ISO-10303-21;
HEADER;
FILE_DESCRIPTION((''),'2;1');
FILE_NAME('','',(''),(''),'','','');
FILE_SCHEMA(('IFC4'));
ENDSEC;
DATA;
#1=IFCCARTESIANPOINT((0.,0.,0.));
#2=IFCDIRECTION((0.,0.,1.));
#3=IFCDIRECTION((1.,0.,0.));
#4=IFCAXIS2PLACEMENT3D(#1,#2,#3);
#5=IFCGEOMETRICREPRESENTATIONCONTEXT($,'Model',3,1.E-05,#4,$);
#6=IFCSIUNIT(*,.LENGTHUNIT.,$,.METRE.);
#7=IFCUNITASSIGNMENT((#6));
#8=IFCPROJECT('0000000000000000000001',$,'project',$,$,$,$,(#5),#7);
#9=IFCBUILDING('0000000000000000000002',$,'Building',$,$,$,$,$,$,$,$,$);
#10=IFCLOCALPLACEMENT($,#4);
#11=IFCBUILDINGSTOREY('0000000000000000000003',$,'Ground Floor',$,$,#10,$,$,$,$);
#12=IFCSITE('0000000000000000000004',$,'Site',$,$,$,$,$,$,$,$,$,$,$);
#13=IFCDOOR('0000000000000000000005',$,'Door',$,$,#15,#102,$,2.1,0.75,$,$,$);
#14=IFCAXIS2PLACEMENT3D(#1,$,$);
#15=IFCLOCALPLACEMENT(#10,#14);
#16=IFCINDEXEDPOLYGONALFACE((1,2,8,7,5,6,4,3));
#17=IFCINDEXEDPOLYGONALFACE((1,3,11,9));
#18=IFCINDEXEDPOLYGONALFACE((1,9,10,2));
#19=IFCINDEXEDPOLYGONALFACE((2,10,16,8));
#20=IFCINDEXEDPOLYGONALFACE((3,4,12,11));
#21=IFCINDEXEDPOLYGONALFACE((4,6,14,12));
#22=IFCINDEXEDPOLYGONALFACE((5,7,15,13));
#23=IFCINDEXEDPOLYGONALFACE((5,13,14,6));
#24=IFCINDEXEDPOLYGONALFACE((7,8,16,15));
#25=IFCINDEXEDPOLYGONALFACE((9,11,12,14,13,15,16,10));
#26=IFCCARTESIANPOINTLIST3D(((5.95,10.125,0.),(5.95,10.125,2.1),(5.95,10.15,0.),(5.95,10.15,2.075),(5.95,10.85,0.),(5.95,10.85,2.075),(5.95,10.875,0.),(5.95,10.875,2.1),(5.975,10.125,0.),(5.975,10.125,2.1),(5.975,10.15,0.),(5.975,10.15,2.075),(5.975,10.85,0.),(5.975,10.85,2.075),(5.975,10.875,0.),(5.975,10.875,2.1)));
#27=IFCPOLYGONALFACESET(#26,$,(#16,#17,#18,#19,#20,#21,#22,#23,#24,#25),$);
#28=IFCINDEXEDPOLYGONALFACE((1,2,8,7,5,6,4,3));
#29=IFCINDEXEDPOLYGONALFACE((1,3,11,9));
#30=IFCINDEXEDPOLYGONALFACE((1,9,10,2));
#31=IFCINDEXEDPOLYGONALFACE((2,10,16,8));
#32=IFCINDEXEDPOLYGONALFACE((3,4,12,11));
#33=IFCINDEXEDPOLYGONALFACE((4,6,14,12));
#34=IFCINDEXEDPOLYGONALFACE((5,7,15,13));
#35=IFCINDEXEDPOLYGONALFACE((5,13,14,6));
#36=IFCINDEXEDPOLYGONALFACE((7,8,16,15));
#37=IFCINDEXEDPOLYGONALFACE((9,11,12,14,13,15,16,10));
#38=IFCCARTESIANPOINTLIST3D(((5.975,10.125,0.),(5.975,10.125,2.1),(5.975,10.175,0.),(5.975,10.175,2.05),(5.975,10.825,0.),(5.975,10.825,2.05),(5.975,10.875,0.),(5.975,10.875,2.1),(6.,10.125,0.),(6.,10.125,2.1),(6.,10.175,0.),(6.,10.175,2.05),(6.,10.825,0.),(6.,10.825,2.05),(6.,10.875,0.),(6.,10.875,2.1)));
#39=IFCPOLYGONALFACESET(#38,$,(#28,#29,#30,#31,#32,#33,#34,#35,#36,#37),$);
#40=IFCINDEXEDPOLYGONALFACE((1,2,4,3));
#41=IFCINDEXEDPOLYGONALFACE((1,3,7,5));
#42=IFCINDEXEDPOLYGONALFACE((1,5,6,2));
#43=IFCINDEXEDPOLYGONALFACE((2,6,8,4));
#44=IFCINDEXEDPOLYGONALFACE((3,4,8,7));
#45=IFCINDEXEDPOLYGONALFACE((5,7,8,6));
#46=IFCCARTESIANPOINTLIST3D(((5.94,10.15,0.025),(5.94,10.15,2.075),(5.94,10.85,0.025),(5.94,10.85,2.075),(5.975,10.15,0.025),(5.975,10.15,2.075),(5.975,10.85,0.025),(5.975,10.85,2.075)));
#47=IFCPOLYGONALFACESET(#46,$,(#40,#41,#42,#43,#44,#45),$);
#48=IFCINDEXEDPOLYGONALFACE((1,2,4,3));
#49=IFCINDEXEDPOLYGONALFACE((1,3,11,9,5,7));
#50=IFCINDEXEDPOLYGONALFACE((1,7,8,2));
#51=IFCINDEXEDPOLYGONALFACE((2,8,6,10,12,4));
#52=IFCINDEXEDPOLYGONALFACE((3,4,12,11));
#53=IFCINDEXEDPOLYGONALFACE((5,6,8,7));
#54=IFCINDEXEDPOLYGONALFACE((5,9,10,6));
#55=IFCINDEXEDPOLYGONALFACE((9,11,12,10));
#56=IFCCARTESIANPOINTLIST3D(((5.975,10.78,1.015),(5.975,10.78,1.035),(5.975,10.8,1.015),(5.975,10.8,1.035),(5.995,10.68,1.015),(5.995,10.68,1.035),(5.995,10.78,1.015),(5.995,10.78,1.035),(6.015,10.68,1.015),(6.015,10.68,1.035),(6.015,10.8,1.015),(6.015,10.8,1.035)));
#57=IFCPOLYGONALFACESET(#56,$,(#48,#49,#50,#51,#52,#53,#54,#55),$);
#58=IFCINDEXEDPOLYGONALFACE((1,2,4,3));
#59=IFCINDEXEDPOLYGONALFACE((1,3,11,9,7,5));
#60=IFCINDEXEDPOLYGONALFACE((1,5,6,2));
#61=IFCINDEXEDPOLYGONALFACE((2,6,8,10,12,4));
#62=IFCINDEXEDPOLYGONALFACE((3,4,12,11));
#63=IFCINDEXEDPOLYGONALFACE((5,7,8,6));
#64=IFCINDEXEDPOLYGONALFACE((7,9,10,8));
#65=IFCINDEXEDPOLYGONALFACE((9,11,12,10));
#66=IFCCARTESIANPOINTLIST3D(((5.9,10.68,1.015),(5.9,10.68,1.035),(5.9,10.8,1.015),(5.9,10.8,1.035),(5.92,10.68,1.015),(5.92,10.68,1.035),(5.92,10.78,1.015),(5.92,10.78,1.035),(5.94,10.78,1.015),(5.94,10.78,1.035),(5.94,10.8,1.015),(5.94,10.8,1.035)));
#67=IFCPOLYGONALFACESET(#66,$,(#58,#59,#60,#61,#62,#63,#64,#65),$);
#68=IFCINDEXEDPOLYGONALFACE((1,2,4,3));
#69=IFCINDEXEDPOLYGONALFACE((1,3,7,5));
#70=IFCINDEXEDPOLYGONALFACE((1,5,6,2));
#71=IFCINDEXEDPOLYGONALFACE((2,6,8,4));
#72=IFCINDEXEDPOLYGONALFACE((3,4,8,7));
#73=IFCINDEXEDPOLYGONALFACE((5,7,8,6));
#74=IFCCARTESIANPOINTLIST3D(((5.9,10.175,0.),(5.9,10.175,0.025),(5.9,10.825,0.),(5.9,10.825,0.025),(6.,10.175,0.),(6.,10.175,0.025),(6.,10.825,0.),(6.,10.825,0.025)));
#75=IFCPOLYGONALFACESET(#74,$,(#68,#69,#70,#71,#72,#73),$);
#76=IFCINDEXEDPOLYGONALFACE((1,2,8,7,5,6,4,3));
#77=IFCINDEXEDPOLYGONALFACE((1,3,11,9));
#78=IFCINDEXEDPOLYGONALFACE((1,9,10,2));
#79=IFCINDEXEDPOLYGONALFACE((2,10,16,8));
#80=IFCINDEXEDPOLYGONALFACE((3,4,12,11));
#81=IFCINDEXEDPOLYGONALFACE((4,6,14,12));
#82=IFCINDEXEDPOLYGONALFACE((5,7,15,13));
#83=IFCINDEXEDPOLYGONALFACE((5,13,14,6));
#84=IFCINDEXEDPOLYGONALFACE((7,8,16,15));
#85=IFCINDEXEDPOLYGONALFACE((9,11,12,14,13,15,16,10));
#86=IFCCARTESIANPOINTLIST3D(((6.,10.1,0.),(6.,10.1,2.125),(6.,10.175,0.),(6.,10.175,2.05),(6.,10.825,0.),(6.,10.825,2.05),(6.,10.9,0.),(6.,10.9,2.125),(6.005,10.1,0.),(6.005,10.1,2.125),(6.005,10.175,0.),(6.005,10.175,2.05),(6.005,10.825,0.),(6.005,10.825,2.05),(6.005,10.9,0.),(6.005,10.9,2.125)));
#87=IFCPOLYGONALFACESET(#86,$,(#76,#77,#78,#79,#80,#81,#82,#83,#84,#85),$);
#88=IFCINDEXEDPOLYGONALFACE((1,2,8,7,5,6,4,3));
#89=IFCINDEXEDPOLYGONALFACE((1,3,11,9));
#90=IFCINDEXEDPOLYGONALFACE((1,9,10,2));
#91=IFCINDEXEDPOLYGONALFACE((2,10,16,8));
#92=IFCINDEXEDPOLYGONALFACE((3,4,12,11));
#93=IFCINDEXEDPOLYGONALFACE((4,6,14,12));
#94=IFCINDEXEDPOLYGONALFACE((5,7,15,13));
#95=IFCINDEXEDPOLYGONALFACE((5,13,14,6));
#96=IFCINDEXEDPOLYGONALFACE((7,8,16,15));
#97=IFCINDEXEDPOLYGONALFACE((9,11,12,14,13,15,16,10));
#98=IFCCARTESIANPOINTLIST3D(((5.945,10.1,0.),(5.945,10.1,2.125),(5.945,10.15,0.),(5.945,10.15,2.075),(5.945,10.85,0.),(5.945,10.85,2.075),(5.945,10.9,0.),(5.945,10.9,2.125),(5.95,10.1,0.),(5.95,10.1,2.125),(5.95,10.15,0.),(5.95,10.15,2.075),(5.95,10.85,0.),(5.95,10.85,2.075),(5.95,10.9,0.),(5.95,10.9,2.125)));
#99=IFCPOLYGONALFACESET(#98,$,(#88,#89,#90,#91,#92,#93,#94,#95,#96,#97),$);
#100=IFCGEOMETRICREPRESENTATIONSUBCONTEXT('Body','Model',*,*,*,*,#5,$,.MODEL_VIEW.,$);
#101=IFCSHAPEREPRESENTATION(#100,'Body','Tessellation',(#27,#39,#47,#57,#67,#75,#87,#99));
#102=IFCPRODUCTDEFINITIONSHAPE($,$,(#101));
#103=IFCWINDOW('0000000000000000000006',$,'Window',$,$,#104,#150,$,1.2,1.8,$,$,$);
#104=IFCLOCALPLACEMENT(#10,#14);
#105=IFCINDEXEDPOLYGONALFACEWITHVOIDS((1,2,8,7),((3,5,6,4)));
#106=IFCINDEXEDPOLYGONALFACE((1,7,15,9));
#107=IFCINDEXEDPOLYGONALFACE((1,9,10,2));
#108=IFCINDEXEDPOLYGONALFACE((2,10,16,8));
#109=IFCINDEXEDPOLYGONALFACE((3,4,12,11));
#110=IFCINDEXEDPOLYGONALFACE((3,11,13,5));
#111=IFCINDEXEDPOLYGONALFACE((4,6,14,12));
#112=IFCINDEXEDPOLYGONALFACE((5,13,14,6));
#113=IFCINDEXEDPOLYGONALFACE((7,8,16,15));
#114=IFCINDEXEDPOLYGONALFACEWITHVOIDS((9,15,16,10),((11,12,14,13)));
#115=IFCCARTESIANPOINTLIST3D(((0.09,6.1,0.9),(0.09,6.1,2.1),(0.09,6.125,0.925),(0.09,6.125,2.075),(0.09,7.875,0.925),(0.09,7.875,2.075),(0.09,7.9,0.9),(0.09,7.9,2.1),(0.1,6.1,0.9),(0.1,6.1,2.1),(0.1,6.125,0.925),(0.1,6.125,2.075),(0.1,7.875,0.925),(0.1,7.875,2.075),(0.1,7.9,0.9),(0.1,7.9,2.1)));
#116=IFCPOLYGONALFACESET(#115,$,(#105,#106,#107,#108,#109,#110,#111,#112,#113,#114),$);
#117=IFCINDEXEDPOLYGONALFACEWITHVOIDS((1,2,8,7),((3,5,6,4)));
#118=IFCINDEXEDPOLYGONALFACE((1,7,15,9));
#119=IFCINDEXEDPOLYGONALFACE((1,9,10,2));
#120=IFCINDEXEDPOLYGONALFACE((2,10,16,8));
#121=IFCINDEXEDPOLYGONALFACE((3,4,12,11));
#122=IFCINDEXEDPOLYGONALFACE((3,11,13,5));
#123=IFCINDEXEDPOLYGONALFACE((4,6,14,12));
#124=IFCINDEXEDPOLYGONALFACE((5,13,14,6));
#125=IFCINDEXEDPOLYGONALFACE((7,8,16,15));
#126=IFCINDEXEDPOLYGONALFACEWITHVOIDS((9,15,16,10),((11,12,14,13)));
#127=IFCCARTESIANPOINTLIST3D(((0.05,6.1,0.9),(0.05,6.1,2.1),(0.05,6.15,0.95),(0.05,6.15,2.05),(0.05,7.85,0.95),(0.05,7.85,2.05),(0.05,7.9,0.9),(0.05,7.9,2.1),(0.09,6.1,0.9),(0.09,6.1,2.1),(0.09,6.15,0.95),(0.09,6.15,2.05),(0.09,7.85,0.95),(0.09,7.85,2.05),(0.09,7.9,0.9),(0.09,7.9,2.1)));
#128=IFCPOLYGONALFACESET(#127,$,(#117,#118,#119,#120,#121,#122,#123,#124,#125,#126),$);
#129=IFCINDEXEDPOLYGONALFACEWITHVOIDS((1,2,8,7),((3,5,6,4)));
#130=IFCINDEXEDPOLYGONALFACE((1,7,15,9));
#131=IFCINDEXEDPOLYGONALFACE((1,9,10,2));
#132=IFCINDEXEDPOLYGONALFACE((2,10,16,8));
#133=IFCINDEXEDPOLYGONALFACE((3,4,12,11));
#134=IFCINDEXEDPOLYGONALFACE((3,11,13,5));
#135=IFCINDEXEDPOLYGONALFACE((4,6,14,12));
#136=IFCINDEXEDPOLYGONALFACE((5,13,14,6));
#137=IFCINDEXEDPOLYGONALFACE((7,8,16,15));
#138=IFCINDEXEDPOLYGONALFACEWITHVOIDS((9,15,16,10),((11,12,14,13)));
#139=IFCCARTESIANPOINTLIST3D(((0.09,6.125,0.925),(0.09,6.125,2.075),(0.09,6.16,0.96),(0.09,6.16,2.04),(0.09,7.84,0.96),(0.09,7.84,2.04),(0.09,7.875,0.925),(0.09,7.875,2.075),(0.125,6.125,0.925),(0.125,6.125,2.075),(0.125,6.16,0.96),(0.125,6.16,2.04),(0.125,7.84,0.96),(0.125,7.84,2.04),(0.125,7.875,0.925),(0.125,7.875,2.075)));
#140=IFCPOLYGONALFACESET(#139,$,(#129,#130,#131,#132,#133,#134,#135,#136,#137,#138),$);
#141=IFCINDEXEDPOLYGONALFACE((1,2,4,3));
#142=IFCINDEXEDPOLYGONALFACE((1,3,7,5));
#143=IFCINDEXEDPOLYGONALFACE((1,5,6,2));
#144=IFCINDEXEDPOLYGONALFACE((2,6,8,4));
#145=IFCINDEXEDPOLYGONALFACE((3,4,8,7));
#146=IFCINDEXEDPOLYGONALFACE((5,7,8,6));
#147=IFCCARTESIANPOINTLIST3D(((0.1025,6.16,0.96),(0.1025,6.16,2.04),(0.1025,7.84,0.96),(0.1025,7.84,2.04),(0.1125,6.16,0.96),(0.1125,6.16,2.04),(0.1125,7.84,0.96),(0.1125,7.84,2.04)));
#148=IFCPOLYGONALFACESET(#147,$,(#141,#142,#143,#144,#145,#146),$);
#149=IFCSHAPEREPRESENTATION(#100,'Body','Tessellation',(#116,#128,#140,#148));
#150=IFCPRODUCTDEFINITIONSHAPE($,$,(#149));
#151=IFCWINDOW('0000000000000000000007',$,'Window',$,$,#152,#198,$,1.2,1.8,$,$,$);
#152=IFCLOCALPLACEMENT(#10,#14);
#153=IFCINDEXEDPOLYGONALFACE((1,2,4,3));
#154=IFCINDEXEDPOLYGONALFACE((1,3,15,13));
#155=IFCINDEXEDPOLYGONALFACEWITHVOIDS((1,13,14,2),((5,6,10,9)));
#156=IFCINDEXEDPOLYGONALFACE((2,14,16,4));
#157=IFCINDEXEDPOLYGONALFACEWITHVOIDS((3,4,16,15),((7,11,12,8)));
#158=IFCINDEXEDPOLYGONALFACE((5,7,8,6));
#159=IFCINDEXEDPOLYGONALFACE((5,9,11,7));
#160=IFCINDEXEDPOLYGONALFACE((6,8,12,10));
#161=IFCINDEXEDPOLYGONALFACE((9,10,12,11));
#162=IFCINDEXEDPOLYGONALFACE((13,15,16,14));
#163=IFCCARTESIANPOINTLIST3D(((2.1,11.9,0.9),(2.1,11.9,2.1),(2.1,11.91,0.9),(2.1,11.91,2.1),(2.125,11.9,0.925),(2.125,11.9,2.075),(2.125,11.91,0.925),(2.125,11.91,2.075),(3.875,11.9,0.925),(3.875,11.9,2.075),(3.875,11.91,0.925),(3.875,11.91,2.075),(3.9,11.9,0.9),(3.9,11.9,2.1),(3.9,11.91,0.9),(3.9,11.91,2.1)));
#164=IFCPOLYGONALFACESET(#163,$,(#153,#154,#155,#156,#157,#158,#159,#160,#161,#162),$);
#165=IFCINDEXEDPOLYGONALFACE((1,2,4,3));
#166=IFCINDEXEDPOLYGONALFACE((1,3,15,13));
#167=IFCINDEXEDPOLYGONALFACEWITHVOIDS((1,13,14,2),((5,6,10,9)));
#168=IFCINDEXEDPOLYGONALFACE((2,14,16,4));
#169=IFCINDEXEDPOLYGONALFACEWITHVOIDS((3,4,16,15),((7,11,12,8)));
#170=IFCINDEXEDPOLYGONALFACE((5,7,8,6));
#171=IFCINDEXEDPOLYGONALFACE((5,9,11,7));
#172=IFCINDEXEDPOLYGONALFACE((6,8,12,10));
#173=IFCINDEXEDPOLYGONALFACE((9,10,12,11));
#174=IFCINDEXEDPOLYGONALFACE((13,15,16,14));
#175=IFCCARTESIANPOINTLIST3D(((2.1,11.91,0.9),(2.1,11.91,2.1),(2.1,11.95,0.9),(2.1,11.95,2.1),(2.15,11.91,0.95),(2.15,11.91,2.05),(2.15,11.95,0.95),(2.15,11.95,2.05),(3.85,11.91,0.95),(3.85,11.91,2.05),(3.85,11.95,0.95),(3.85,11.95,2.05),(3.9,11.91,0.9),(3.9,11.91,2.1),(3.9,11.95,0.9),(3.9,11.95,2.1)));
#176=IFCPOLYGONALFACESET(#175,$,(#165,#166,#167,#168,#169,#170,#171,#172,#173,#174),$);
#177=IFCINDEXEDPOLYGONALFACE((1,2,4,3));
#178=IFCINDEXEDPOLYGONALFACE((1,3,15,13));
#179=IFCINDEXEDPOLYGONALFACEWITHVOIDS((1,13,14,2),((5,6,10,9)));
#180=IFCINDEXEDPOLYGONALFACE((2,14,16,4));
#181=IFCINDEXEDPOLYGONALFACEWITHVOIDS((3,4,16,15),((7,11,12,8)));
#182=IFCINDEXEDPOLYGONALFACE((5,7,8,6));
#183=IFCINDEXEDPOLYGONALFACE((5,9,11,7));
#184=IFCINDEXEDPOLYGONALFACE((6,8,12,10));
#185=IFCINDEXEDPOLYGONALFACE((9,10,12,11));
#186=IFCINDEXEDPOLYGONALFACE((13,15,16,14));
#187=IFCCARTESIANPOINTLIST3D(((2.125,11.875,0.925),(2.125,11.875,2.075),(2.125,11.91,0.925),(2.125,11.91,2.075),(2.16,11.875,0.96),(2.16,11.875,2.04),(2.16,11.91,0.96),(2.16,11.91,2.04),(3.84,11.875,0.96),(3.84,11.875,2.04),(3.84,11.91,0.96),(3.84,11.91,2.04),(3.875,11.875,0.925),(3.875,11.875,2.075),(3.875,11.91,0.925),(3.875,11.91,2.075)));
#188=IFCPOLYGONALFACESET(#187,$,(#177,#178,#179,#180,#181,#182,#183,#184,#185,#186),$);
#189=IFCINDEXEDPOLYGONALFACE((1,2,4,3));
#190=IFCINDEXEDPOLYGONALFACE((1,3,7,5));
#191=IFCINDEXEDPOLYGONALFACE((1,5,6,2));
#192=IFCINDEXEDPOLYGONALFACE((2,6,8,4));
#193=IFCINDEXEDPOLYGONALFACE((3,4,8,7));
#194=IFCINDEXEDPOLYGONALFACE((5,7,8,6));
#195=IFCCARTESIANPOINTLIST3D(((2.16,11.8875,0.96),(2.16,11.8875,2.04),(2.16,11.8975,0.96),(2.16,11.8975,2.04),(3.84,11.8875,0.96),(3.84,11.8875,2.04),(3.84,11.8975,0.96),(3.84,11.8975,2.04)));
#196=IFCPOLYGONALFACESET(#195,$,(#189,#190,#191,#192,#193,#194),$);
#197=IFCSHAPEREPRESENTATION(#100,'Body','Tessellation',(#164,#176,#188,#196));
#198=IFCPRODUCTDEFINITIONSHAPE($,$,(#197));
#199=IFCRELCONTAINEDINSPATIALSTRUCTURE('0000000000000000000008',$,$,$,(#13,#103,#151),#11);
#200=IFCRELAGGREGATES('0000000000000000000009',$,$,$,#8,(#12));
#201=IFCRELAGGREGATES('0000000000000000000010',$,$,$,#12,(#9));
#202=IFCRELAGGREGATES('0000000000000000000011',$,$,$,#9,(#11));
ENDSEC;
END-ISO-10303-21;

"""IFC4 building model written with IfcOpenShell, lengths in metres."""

from ifc_helpers import new_model, si_unit, frame, origin_with_axes, place, context, subcontext, project, spatial, line, indexed_curve, outline, extrude, element, save


model = new_model("IFC4")

# Units and contexts
model_context = context("Model", 3, precision=1e-05, world=origin_with_axes())
body_context = subcontext(model_context, "Body", "Model", "MODEL_VIEW")
ifc_project = project(units=[si_unit("LENGTHUNIT", "METRE")], contexts=[model_context])

# Site, building, storey
site = spatial("IfcSite", under=ifc_project, Name="Site")
building = spatial("IfcBuilding", under=site, Name="Building")
storey_placement = place(None, origin_with_axes())
storey = spatial("IfcBuildingStorey", under=building, at=storey_placement, Name="Ground Floor")

# Door
door_1_placement = place(storey_placement, frame((6.0, 10.125, 0.0), z_axis=(0.0, 0.0, 1.0), x_axis=(0.0, 1.0, 0.0)))
element("IfcDoor", 1, at=door_1_placement, inside=storey, Name="Door", OverallHeight=2.1, OverallWidth=0.75, context=body_context, shape_type="SweptSolid", body=[
    extrude(outline(indexed_curve([(0.0, 0.0), (0.0, 2.1), (0.75, 2.1), (0.75, 0.0), (0.725, 0.0), (0.725, 2.075), (0.025, 2.075), (0.025, 0.0)], segments=[line(1, 2, 3, 4, 5, 6, 7, 8, 1)])), frame((0.0, 0.025, 0.0), z_axis=(0.0, -1.0, 0.0), x_axis=(1.0, 0.0, 0.0)), (0.0, 0.0, -1.0), 0.025),
    extrude(outline(indexed_curve([(0.0, 0.0), (0.0, 2.1), (0.75, 2.1), (0.75, 0.0), (0.7, 0.0), (0.7, 2.05), (0.05, 2.05), (0.05, 0.0)], segments=[line(1, 2, 3, 4, 5, 6, 7, 8, 1)])), frame((0.0, 0.0, 0.0), z_axis=(0.0, -1.0, 0.0), x_axis=(1.0, 0.0, 0.0)), (0.0, 0.0, -1.0), 0.025),
    extrude(outline(indexed_curve([(0.0, 0.0), (0.7, 0.0), (0.7, 0.035), (0.0, 0.035)], segments=[line(1, 2, 3, 4, 1)])), frame((0.025, 0.025, 0.025), z_axis=(0.0, 0.0, 1.0), x_axis=(1.0, 0.0, 0.0)), (0.0, 0.0, 1.0), 2.05),
    extrude(outline(indexed_curve([(0.0, 0.0), (0.0, -0.04), (-0.12, -0.04), (-0.12, -0.02), (-0.02, -0.02), (-0.02, 0.0)], segments=[line(1, 2, 3, 4, 5, 6, 1)])), frame((0.675, 0.025, 1.015), z_axis=(0.0, 0.0, 1.0), x_axis=(1.0, 0.0, 0.0)), (0.0, 0.0, 1.0), 0.02),
    extrude(outline(indexed_curve([(0.0, 0.0), (0.0, 0.04), (-0.12, 0.04), (-0.12, 0.02), (-0.02, 0.02), (-0.02, 0.0)], segments=[line(1, 2, 3, 4, 5, 6, 1)])), frame((0.675, 0.06, 1.015), z_axis=(0.0, 0.0, 1.0), x_axis=(1.0, 0.0, 0.0)), (0.0, 0.0, 1.0), 0.02),
    extrude(outline(indexed_curve([(0.0, 0.0), (0.65, 0.0), (0.65, 0.1), (0.0, 0.1)], segments=[line(1, 2, 3, 4, 1)])), frame((0.05, 0.0, 0.0), z_axis=(0.0, 0.0, 1.0), x_axis=(1.0, 0.0, 0.0)), (0.0, 0.0, 1.0), 0.025),
    extrude(outline(indexed_curve([(0.0, 0.0), (0.0, 2.125), (0.8, 2.125), (0.8, 0.0), (0.725, 0.0), (0.725, 2.05), (0.075, 2.05), (0.075, 0.0)], segments=[line(1, 2, 3, 4, 5, 6, 7, 8, 1)])), frame((-0.025, -0.005, 0.0), z_axis=(0.0, -1.0, 0.0), x_axis=(1.0, 0.0, 0.0)), (0.0, 0.0, -1.0), 0.005),
    extrude(outline(indexed_curve([(0.0, 0.0), (0.0, 2.125), (0.8, 2.125), (0.8, 0.0), (0.75, 0.0), (0.75, 2.075), (0.05, 2.075), (0.05, 0.0)], segments=[line(1, 2, 3, 4, 5, 6, 7, 8, 1)])), frame((-0.025, 0.05, 0.0), z_axis=(0.0, -1.0, 0.0), x_axis=(1.0, 0.0, 0.0)), (0.0, 0.0, -1.0), 0.005),
])

# Windows
for number, where, z_axis, x_axis, name in (
    (2, (0.0, 7.9, 0.9), (0.0, 0.0, 1.0), (0.0, -1.0, 0.0), "Window"),
    (3, (3.9, 12.0, 0.9), (0.0, 0.0, 1.0), (-1.0, 0.0, 0.0), "Window"),
):
    element("IfcWindow", number, at=place(storey_placement, frame(where, z_axis=z_axis, x_axis=x_axis)), inside=storey, Name=name, OverallHeight=1.2, OverallWidth=1.8, context=body_context, shape_type="SweptSolid", body=[
        extrude(outline(indexed_curve([(0.0, 0.0), (1.8, 0.0), (1.8, 1.2), (0.0, 1.2)], segments=[line(1, 2, 3, 4, 1)]), holes=[indexed_curve([(0.025, 0.025), (1.775, 0.025), (1.775, 1.175), (0.025, 1.175)], segments=[line(1, 2, 3, 4, 1)])]), frame((0.0, 0.09, 0.0), z_axis=(0.0, -1.0, 0.0), x_axis=(1.0, 0.0, 0.0)), (0.0, 0.0, -1.0), 0.01),
        extrude(outline(indexed_curve([(0.0, 0.0), (1.8, 0.0), (1.8, 1.2), (0.0, 1.2)], segments=[line(1, 2, 3, 4, 1)]), holes=[indexed_curve([(0.05, 0.05), (1.75, 0.05), (1.75, 1.15), (0.05, 1.15)], segments=[line(1, 2, 3, 4, 1)])]), frame((0.0, 0.05, 0.0), z_axis=(0.0, -1.0, 0.0), x_axis=(1.0, 0.0, 0.0)), (0.0, 0.0, -1.0), 0.04),
        extrude(outline(indexed_curve([(0.0, 0.0), (1.75, 0.0), (1.75, 1.15), (0.0, 1.15)], segments=[line(1, 2, 3, 4, 1)]), holes=[indexed_curve([(0.035, 0.035), (1.715, 0.035), (1.715, 1.115), (0.035, 1.115)], segments=[line(1, 2, 3, 4, 1)])]), frame((0.025, 0.09, 0.025), z_axis=(0.0, -1.0, 0.0), x_axis=(1.0, 0.0, 0.0)), (0.0, 0.0, -1.0), 0.035),
        extrude(outline(indexed_curve([(0.035, 0.035), (1.715, 0.035), (1.715, 1.115), (0.035, 1.115)], segments=[line(1, 2, 3, 4, 1)])), frame((0.025, 0.1025, 0.025), z_axis=(0.0, -1.0, 0.0), x_axis=(1.0, 0.0, 0.0)), (0.0, 0.0, -1.0), 0.01),
    ])

save(model, "model.ifc")
